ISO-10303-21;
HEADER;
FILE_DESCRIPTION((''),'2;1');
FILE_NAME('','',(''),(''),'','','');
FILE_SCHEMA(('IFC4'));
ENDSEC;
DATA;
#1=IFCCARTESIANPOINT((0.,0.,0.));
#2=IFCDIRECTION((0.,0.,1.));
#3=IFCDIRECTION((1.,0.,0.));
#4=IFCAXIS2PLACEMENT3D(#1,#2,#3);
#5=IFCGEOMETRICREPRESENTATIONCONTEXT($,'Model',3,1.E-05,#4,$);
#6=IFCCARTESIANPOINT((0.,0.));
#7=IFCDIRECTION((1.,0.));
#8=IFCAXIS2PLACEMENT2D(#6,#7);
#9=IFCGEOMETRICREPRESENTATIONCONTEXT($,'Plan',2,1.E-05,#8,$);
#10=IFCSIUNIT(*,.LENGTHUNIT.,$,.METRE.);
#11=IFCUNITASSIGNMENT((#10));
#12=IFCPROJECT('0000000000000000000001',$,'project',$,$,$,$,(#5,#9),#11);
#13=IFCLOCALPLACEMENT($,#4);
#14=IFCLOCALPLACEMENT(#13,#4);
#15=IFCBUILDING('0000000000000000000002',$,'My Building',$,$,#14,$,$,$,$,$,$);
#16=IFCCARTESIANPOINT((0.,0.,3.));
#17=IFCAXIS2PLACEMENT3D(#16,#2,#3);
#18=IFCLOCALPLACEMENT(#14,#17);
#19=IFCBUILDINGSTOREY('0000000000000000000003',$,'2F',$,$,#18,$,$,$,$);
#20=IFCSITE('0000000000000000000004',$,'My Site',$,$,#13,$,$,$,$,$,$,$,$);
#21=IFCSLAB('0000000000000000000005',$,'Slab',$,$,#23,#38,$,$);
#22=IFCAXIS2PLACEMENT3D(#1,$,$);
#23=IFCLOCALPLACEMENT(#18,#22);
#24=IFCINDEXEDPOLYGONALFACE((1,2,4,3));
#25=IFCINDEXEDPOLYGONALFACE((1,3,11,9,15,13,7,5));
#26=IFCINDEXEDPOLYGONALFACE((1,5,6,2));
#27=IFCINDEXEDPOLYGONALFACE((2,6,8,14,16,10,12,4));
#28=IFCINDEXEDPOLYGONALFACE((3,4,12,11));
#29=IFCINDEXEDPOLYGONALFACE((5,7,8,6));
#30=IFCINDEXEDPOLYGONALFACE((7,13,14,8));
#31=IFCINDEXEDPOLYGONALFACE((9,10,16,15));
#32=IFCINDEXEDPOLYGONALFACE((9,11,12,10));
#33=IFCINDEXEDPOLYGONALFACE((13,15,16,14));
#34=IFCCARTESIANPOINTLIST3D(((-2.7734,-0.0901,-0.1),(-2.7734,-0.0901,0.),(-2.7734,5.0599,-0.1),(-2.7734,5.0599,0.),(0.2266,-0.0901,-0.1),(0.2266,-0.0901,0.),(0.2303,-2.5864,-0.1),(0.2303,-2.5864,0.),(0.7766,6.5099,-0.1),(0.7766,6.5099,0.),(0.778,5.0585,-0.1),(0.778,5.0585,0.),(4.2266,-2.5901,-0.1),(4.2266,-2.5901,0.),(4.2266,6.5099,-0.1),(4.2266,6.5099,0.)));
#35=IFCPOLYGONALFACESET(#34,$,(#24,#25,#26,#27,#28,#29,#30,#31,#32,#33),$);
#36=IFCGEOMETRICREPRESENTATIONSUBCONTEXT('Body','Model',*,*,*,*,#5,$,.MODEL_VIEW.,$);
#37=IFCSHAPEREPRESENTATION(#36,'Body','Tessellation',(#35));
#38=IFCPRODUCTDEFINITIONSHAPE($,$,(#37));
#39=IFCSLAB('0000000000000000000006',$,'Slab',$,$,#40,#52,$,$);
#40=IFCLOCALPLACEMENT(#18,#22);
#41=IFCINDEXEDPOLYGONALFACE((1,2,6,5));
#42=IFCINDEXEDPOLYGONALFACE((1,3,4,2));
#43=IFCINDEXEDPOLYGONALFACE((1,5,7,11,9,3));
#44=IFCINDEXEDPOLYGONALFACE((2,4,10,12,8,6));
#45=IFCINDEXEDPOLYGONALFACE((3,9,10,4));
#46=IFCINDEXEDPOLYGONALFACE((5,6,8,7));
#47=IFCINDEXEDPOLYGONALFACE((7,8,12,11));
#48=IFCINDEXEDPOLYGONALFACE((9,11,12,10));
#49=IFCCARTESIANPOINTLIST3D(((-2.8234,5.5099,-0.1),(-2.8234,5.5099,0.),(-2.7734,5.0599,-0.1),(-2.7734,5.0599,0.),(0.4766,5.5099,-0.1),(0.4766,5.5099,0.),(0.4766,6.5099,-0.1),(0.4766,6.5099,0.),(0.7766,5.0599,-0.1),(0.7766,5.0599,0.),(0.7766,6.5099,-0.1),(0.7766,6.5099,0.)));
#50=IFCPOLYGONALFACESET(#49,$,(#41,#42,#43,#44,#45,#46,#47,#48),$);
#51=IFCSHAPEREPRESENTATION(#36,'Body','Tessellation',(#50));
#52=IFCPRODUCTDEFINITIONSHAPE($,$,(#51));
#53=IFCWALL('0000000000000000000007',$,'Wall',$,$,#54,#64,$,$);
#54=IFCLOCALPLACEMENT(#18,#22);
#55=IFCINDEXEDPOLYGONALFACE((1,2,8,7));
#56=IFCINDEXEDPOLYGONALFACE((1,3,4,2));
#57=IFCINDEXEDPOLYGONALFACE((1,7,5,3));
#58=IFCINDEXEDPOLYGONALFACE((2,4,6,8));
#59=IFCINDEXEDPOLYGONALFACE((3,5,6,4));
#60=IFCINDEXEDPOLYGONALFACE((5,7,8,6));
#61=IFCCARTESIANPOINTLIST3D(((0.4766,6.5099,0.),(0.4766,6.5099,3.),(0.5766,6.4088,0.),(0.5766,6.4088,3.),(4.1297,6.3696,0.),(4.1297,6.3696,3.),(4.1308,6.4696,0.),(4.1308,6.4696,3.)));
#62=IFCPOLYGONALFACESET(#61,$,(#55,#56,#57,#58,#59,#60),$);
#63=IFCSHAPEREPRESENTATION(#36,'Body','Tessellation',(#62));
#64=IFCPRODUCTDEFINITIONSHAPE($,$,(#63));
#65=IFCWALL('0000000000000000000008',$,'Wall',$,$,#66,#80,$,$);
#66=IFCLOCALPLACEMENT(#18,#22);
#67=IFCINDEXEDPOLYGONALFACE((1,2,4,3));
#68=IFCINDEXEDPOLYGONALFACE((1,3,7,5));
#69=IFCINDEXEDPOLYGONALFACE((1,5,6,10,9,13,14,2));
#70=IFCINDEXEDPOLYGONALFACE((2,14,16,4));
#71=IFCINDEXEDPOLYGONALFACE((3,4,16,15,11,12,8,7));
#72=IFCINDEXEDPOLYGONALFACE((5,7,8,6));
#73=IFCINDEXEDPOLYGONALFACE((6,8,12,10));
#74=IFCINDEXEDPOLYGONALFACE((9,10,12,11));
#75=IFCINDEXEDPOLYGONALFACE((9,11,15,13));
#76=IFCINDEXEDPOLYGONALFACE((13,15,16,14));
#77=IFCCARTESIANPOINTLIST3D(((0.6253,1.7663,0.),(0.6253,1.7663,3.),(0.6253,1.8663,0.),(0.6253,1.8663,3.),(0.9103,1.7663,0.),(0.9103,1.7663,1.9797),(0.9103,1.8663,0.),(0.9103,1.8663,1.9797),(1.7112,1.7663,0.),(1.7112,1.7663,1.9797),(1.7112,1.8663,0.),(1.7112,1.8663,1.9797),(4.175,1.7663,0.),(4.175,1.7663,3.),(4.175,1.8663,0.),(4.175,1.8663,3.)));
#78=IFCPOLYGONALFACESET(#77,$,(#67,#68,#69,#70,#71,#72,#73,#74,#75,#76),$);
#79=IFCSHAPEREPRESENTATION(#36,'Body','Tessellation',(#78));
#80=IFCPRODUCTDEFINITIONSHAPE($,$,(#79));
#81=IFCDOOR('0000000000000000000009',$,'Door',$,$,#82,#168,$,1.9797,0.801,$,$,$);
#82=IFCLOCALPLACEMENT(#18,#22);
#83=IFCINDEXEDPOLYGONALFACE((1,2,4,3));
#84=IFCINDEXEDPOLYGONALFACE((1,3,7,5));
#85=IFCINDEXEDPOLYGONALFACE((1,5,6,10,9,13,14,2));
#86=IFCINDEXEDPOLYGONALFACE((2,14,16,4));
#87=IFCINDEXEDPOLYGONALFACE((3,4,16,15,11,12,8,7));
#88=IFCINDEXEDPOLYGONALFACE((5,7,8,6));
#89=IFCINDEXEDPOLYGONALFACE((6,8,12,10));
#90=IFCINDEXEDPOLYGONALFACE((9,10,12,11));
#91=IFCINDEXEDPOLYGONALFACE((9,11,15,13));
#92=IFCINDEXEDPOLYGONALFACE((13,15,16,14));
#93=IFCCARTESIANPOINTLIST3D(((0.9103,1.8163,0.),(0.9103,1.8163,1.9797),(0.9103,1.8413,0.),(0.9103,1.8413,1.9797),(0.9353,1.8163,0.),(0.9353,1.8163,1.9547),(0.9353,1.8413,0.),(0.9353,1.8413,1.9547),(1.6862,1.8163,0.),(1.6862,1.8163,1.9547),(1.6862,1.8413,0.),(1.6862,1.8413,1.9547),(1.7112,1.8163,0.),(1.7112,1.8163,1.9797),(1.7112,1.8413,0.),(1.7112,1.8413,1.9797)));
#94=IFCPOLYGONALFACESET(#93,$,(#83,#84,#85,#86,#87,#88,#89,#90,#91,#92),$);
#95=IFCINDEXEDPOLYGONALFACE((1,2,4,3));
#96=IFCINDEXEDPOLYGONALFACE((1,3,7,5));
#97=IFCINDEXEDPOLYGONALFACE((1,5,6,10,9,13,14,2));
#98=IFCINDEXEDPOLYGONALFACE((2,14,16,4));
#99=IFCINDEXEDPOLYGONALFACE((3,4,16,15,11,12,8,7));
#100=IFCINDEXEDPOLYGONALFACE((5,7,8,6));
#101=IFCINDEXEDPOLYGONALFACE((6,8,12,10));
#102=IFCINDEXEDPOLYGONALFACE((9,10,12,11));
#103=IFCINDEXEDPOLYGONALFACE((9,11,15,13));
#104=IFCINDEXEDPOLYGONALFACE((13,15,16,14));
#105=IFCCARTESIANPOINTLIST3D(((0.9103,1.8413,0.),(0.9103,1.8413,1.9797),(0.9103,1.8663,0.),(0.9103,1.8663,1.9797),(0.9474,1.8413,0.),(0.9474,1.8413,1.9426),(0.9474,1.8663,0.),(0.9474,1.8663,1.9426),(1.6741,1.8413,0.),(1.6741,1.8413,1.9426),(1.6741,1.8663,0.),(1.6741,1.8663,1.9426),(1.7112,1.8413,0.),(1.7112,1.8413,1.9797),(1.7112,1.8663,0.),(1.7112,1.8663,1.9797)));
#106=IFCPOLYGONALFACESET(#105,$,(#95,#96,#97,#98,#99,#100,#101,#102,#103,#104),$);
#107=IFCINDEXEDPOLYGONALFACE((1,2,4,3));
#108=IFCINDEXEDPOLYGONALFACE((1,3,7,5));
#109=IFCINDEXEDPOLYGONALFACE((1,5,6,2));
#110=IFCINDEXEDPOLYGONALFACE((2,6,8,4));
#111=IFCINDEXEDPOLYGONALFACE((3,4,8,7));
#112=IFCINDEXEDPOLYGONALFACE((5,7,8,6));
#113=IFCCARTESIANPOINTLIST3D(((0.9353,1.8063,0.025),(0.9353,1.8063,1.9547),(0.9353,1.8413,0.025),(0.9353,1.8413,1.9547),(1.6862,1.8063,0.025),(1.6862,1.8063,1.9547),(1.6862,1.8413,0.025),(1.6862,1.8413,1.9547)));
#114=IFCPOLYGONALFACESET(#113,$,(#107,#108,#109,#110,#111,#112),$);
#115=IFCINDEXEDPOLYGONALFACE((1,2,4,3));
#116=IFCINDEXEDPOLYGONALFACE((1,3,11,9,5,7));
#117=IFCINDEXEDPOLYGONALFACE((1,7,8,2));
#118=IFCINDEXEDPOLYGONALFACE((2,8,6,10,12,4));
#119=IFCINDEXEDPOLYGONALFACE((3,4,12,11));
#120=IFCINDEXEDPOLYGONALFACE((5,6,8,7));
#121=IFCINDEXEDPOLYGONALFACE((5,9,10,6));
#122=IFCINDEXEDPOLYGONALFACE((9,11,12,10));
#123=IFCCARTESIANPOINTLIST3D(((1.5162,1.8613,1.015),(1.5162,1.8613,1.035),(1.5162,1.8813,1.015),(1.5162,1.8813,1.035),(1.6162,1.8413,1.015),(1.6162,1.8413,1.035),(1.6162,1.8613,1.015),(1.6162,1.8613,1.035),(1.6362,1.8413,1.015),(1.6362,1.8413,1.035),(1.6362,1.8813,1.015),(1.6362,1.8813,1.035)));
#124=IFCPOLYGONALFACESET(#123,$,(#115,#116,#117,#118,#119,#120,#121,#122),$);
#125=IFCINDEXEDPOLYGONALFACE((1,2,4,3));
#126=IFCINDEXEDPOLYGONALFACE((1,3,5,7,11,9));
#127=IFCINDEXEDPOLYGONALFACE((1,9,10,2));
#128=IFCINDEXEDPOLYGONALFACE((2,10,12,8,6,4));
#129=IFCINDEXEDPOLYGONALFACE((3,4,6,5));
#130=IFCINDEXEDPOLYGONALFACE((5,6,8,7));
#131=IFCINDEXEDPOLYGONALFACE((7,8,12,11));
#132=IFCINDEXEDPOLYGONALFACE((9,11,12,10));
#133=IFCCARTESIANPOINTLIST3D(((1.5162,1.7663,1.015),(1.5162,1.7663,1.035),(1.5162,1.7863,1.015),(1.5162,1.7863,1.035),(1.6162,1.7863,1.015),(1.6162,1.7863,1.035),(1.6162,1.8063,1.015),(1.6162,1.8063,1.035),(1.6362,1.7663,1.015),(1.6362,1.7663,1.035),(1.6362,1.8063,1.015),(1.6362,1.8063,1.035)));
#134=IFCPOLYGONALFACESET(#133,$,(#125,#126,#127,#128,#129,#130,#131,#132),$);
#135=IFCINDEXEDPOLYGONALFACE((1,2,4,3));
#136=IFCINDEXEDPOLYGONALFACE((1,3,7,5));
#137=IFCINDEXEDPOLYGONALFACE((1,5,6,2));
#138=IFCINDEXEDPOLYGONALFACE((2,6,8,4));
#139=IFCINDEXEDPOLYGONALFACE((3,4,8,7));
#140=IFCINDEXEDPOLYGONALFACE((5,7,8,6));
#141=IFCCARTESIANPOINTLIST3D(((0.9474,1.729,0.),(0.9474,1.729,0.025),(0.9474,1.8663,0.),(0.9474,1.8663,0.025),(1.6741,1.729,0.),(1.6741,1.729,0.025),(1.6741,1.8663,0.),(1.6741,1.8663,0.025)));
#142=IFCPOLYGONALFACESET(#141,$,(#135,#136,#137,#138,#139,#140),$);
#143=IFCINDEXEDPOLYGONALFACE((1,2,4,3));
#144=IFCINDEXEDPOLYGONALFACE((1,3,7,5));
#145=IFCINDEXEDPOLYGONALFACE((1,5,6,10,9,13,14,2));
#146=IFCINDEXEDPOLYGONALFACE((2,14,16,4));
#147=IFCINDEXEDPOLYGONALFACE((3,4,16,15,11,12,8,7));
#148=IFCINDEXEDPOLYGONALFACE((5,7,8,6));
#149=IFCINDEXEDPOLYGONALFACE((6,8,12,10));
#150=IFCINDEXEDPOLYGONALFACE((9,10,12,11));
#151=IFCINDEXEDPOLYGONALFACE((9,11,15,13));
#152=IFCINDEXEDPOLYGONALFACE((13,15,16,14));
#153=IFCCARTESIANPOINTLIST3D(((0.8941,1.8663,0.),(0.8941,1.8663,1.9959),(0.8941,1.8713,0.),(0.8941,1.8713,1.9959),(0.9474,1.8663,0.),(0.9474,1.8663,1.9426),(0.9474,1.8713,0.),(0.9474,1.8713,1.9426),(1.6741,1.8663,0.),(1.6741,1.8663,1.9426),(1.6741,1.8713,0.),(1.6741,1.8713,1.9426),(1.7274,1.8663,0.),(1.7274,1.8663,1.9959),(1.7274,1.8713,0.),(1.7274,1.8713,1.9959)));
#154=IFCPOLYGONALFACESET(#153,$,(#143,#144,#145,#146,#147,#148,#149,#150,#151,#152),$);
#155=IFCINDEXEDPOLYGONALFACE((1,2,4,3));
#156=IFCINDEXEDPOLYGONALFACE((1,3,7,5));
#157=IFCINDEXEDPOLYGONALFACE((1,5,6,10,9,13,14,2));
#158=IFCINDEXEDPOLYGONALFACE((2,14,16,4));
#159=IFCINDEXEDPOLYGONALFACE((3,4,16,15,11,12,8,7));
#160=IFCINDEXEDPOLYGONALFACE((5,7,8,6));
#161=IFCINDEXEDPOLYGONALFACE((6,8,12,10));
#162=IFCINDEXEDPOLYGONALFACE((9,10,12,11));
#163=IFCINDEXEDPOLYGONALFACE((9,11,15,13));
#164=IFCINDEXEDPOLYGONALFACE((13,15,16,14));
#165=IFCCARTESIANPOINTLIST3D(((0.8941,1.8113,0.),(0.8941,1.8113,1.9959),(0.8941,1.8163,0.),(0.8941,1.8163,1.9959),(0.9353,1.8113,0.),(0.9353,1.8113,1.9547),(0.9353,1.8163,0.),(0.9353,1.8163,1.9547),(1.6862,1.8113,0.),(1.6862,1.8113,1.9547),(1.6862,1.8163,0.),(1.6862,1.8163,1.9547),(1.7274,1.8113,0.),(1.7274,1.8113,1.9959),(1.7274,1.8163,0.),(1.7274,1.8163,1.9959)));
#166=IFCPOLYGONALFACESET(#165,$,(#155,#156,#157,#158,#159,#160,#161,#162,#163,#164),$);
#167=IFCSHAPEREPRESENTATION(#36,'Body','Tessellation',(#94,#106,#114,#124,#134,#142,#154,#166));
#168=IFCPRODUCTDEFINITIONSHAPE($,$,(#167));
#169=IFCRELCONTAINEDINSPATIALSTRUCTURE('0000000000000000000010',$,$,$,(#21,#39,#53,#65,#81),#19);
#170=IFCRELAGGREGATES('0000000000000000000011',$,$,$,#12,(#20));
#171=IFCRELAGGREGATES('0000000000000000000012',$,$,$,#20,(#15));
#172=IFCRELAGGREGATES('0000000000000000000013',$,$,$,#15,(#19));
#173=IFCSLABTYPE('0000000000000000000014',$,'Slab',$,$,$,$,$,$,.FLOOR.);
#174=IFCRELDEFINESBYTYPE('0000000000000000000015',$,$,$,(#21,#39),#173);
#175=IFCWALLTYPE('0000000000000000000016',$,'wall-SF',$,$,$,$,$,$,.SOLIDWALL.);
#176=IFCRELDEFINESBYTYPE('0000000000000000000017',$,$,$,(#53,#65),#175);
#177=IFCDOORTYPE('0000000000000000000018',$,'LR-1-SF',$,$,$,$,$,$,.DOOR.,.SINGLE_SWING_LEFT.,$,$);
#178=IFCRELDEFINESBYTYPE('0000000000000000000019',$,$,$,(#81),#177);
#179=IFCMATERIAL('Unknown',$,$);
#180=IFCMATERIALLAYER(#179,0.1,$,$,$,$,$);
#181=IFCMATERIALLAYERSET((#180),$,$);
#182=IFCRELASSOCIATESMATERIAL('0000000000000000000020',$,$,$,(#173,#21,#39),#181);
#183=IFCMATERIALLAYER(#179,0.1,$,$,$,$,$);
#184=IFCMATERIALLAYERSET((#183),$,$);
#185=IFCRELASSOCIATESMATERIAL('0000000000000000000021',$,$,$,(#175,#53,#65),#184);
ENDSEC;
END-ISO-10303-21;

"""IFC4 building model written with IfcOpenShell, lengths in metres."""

from ifc_helpers import new_model, entity, si_unit, frame, origin_with_axes, origin_2d_with_axis, place, context, subcontext, project, spatial, line, indexed_curve, outline, extrude, shape, source, transform, mapped, material, layer, layer_set, layer_usage, type_object, type_shapes, element, fill, save


model = new_model("IFC4")

# Units and contexts
model_context = context("Model", 3, precision=1e-05, world=origin_with_axes())
plan_context = context("Plan", 2, precision=1e-05, world=origin_2d_with_axis())
body_context_1 = subcontext(model_context, "Body", "Model", "MODEL_VIEW")
body_context_2 = subcontext(plan_context, "Body", "Plan", "PLAN_VIEW")
ifc_project = project(units=[si_unit("LENGTHUNIT", "METRE")], contexts=[model_context, plan_context])

# Site, building, storey
site_placement = place(None, origin_with_axes())
site = spatial("IfcSite", under=ifc_project, at=site_placement, Name="My Site")
building_placement = place(site_placement, origin_with_axes())
building = spatial("IfcBuilding", under=site, at=building_placement, Name="My Building")
storey_placement = place(building_placement, frame((0.0, 0.0, 3.0), z_axis=(0.0, 0.0, 1.0), x_axis=(1.0, 0.0, 0.0)))
storey = spatial("IfcBuildingStorey", under=building, at=storey_placement, Name="2F")

# Slabs
ifc_material = material(Name="Unknown")
ifc_layer_1 = layer(ifc_material, 0.1)
ifc_layer_set_1 = layer_set([ifc_layer_1])
ifc_layer_usage_1 = layer_usage(ifc_layer_set_1, "AXIS3", "POSITIVE", -0.1)
slab_type = type_object("IfcSlabType", Name="Slab", PredefinedType="FLOOR", material=ifc_layer_set_1)
slab_1_placement = place(storey_placement, frame((0.7766, 6.5099, 0.0), z_axis=(0.0, 0.0, 1.0), x_axis=(1.0, 0.0, 0.0)))
element("IfcSlab", 1, at=slab_1_placement, inside=storey, type_object=slab_type, material=ifc_layer_usage_1, Name="Slab", context=body_context_1, shape_type="SweptSolid", body=[
    extrude(outline(indexed_curve([(0.0, 0.0), (3.45, 0.0), (3.45, -9.1), (-0.5463, -9.0963), (-0.55, -6.6), (-3.55, -6.6), (-3.55, -1.45), (0.0014, -1.4514), (0.0, 0.0)])), frame((0.0, 0.0, -0.1), z_axis=(0.0, 0.0, 1.0), x_axis=(1.0, 0.0, 0.0)), (0.0, 0.0, 1.0), 0.1),
])
ifc_layer_usage_2 = layer_usage(ifc_layer_set_1, "AXIS3", "POSITIVE", -0.1)
slab_2_placement = place(storey_placement, frame((0.7766, 6.5099, 0.0), z_axis=(0.0, 0.0, 1.0), x_axis=(1.0, 0.0, 0.0)))
element("IfcSlab", 2, at=slab_2_placement, inside=storey, type_object=slab_type, material=ifc_layer_usage_2, Name="Slab", context=body_context_1, shape_type="SweptSolid", body=[
    extrude(outline(indexed_curve([(0.0, 0.0), (-0.3, 0.0), (-0.3, -1.0), (-3.6, -1.0), (-3.55, -1.45), (0.0, -1.45), (0.0, 0.0)])), frame((0.0, 0.0, -0.1), z_axis=(0.0, 0.0, 1.0), x_axis=(1.0, 0.0, 0.0)), (0.0, 0.0, 1.0), 0.1),
])

# Wall
ifc_layer_2 = layer(ifc_material, 0.1)
ifc_layer_set_2 = layer_set([ifc_layer_2])
ifc_layer_usage_3 = layer_usage(ifc_layer_set_2, "AXIS2", "POSITIVE", 0.0)
wall_type = type_object("IfcWallType", Name="wall-SF", PredefinedType="SOLIDWALL", material=ifc_layer_set_2)
wall_1_placement = place(storey_placement, frame((4.1308, 6.4696, 0.0), z_axis=(0.0, 0.0, 1.0), x_axis=(-0.999939, 0.011034, 0.0)))
element("IfcWall", 3, at=wall_1_placement, inside=storey, type_object=wall_type, material=ifc_layer_usage_3, Name="Wall", context=body_context_1, shape_type="SweptSolid", body=[
    extrude(outline(indexed_curve([(0.0, 0.0), (0.0, 0.1), (3.5533, 0.1), (3.6544, 0.0)], segments=[line(1, 2, 3, 4, 1)])), origin_with_axes(), (0.0, 0.0, 1.0), 3.0),
])

# Wall, opening, door
ifc_layer_usage_4 = layer_usage(ifc_layer_set_2, "AXIS2", "POSITIVE", 0.0)
wall_2_placement = place(storey_placement, frame((0.6253, 1.7663, 0.0), z_axis=(0.0, 0.0, 1.0), x_axis=(1.0, 0.0, 0.0)))
wall_2 = element("IfcWall", 4, at=wall_2_placement, inside=storey, type_object=wall_type, material=ifc_layer_usage_4, Name="Wall", context=body_context_1, shape_type="SweptSolid", body=[
    extrude(outline(indexed_curve([(0.0, 0.0), (0.0, 0.1), (3.5497, 0.1), (3.5497, 0.0)], segments=[line(1, 2, 3, 4, 1)])), origin_with_axes(), (0.0, 0.0, 1.0), 3.0),
])
shared_shape_1 = source(origin_with_axes(), body_context_1, "Body", "SweptSolid", [
    extrude(outline(indexed_curve([(0.0, 0.0), (0.801, 0.0), (0.801, 1.9797), (0.0, 1.9797)], segments=[line(1, 2, 3, 4, 1)])), frame((0.0, -0.6, 0.0), z_axis=(0.0, -1.0, 0.0), x_axis=(1.0, 0.0, 0.0)), (0.0, 0.0, -1.0), 1.2),
])
opening_1_placement = place(wall_2_placement, frame((1.0859, 0.1, 0.0), z_axis=(0.0, 0.0, 1.0), x_axis=(-1.0, 0.0, 0.0)))
opening_1 = element("IfcOpeningElement", 5, at=opening_1_placement, cuts=wall_2, PredefinedType="OPENING", context=body_context_1, shape_type="MappedRepresentation", body=[
    mapped(shared_shape_1, transform((0.0, 0.0, 0.0), x_axis=(1.0, 0.0, 0.0), y_axis=(0.0, 1.0, 0.0), z_axis=(0.0, 0.0, 1.0), scale=1.0)),
])
door_type_1 = type_object("IfcDoorType", Name="LR-1-SF", OperationType="SINGLE_SWING_LEFT", PredefinedType="DOOR")
shared_shape_2 = source(origin_with_axes(), body_context_1, "Body", "SweptSolid", [
    extrude(outline(indexed_curve([(0.0, 0.0), (0.0, 1.9797), (0.801, 1.9797), (0.801, 0.0), (0.776, 0.0), (0.776, 1.9547), (0.025, 1.9547), (0.025, 0.0)], segments=[line(1, 2, 3, 4, 5, 6, 7, 8, 1)])), frame((0.0, 0.025, 0.0), z_axis=(0.0, -1.0, 0.0), x_axis=(1.0, 0.0, 0.0)), (0.0, 0.0, -1.0), 0.025),
    extrude(outline(indexed_curve([(0.0, 0.0), (0.0, 1.9797), (0.801, 1.9797), (0.801, 0.0), (0.7639, 0.0), (0.7639, 1.9426), (0.0371, 1.9426), (0.0371, 0.0)], segments=[line(1, 2, 3, 4, 5, 6, 7, 8, 1)])), frame((0.0, 0.0, 0.0), z_axis=(0.0, -1.0, 0.0), x_axis=(1.0, 0.0, 0.0)), (0.0, 0.0, -1.0), 0.025),
    extrude(outline(indexed_curve([(0.0, 0.0), (0.751, 0.0), (0.751, 0.035), (0.0, 0.035)], segments=[line(1, 2, 3, 4, 1)])), frame((0.025, 0.025, 0.025), z_axis=(0.0, 0.0, 1.0), x_axis=(1.0, 0.0, 0.0)), (0.0, 0.0, 1.0), 1.9297),
    extrude(outline(indexed_curve([(0.0, 0.0), (0.0, -0.04), (0.12, -0.04), (0.12, -0.02), (0.02, -0.02), (0.02, 0.0)], segments=[line(1, 2, 3, 4, 5, 6, 1)])), frame((0.075, 0.025, 1.015), z_axis=(0.0, 0.0, 1.0), x_axis=(1.0, 0.0, 0.0)), (0.0, 0.0, 1.0), 0.02),
    extrude(outline(indexed_curve([(0.0, 0.0), (0.0, 0.04), (0.12, 0.04), (0.12, 0.02), (0.02, 0.02), (0.02, 0.0)], segments=[line(1, 2, 3, 4, 5, 6, 1)])), frame((0.075, 0.06, 1.015), z_axis=(0.0, 0.0, 1.0), x_axis=(1.0, 0.0, 0.0)), (0.0, 0.0, 1.0), 0.02),
    extrude(outline(indexed_curve([(0.0, 0.0), (0.7268, 0.0), (0.7268, 0.1372), (0.0, 0.1372)], segments=[line(1, 2, 3, 4, 1)])), frame((0.0371, 0.0, 0.0), z_axis=(0.0, 0.0, 1.0), x_axis=(1.0, 0.0, 0.0)), (0.0, 0.0, 1.0), 0.025),
    extrude(outline(indexed_curve([(0.0, 0.0), (0.0, 1.9959), (0.8333, 1.9959), (0.8333, 0.0), (0.78, 0.0), (0.78, 1.9426), (0.0532, 1.9426), (0.0532, 0.0)], segments=[line(1, 2, 3, 4, 5, 6, 7, 8, 1)])), frame((-0.0162, -0.005, 0.0), z_axis=(0.0, -1.0, 0.0), x_axis=(1.0, 0.0, 0.0)), (0.0, 0.0, -1.0), 0.005),
    extrude(outline(indexed_curve([(0.0, 0.0), (0.0, 1.9959), (0.8333, 1.9959), (0.8333, 0.0), (0.7921, 0.0), (0.7921, 1.9547), (0.0412, 1.9547), (0.0412, 0.0)], segments=[line(1, 2, 3, 4, 5, 6, 7, 8, 1)])), frame((-0.0162, 0.05, 0.0), z_axis=(0.0, -1.0, 0.0), x_axis=(1.0, 0.0, 0.0)), (0.0, 0.0, -1.0), 0.005),
])
shared_shape_3 = source(origin_with_axes(), body_context_2, "Body", "Curve2D", [
    entity("IfcIndexedPolyCurve", entity("IfcCartesianPointList2D", [[0.0, 0.0], [0.0, 0.05], [0.025, 0.05], [0.025, 0.025], [0.0371, 0.025], [0.0371, 0.0]]), [entity("IfcLineIndex", [1, 2, 3, 4, 5, 6, 1])]),
    entity("IfcIndexedPolyCurve", entity("IfcCartesianPointList2D", [[0.801, 0.0], [0.801, 0.05], [0.776, 0.05], [0.776, 0.025], [0.7639, 0.025], [0.7639, 0.0]]), [entity("IfcLineIndex", [1, 2, 3, 4, 5, 6, 1])]),
    entity("IfcTrimmedCurve", entity("IfcEllipse", entity("IfcAxis2Placement2D", entity("IfcCartesianPoint", [0.741, 0.05]), entity("IfcDirection", [1.0, 0.0])), 0.716, 0.751), [entity("IfcCartesianPoint", [0.741, 0.801])], [entity("IfcCartesianPoint", [0.025, 0.05])], True, "CARTESIAN"),
    entity("IfcIndexedPolyCurve", entity("IfcCartesianPointList2D", [[0.776, 0.05], [0.741, 0.05], [0.741, 0.801], [0.776, 0.801]]), [entity("IfcLineIndex", [1, 2, 3, 4, 1])]),
])
type_shapes(door_type_1, [shared_shape_2, shared_shape_3])
door_1_placement = place(opening_1_placement, frame((0.0, 0.0, 0.0), z_axis=(0.0, 0.0, 1.0), x_axis=(1.0, 0.0, 0.0)))
door_1 = element("IfcDoor", 6, at=door_1_placement, inside=storey, type_object=door_type_1, Name="Door", OverallHeight=1.9797, OverallWidth=0.801, shapes=[
    shape(body_context_1, "Body", "MappedRepresentation", [mapped(shared_shape_2, transform((0.0, 0.0, 0.0), x_axis=(1.0, 0.0, 0.0), y_axis=(0.0, 1.0, 0.0), z_axis=(0.0, 0.0, 1.0), scale=1.0))]),
    shape(body_context_2, "Body", "MappedRepresentation", [mapped(shared_shape_3, transform((0.0, 0.0, 0.0), x_axis=(1.0, 0.0, 0.0), y_axis=(0.0, 1.0, 0.0), z_axis=(0.0, 0.0, 1.0), scale=1.0))]),
])
fill(opening_1, door_1)

save(model, "model.ifc")
